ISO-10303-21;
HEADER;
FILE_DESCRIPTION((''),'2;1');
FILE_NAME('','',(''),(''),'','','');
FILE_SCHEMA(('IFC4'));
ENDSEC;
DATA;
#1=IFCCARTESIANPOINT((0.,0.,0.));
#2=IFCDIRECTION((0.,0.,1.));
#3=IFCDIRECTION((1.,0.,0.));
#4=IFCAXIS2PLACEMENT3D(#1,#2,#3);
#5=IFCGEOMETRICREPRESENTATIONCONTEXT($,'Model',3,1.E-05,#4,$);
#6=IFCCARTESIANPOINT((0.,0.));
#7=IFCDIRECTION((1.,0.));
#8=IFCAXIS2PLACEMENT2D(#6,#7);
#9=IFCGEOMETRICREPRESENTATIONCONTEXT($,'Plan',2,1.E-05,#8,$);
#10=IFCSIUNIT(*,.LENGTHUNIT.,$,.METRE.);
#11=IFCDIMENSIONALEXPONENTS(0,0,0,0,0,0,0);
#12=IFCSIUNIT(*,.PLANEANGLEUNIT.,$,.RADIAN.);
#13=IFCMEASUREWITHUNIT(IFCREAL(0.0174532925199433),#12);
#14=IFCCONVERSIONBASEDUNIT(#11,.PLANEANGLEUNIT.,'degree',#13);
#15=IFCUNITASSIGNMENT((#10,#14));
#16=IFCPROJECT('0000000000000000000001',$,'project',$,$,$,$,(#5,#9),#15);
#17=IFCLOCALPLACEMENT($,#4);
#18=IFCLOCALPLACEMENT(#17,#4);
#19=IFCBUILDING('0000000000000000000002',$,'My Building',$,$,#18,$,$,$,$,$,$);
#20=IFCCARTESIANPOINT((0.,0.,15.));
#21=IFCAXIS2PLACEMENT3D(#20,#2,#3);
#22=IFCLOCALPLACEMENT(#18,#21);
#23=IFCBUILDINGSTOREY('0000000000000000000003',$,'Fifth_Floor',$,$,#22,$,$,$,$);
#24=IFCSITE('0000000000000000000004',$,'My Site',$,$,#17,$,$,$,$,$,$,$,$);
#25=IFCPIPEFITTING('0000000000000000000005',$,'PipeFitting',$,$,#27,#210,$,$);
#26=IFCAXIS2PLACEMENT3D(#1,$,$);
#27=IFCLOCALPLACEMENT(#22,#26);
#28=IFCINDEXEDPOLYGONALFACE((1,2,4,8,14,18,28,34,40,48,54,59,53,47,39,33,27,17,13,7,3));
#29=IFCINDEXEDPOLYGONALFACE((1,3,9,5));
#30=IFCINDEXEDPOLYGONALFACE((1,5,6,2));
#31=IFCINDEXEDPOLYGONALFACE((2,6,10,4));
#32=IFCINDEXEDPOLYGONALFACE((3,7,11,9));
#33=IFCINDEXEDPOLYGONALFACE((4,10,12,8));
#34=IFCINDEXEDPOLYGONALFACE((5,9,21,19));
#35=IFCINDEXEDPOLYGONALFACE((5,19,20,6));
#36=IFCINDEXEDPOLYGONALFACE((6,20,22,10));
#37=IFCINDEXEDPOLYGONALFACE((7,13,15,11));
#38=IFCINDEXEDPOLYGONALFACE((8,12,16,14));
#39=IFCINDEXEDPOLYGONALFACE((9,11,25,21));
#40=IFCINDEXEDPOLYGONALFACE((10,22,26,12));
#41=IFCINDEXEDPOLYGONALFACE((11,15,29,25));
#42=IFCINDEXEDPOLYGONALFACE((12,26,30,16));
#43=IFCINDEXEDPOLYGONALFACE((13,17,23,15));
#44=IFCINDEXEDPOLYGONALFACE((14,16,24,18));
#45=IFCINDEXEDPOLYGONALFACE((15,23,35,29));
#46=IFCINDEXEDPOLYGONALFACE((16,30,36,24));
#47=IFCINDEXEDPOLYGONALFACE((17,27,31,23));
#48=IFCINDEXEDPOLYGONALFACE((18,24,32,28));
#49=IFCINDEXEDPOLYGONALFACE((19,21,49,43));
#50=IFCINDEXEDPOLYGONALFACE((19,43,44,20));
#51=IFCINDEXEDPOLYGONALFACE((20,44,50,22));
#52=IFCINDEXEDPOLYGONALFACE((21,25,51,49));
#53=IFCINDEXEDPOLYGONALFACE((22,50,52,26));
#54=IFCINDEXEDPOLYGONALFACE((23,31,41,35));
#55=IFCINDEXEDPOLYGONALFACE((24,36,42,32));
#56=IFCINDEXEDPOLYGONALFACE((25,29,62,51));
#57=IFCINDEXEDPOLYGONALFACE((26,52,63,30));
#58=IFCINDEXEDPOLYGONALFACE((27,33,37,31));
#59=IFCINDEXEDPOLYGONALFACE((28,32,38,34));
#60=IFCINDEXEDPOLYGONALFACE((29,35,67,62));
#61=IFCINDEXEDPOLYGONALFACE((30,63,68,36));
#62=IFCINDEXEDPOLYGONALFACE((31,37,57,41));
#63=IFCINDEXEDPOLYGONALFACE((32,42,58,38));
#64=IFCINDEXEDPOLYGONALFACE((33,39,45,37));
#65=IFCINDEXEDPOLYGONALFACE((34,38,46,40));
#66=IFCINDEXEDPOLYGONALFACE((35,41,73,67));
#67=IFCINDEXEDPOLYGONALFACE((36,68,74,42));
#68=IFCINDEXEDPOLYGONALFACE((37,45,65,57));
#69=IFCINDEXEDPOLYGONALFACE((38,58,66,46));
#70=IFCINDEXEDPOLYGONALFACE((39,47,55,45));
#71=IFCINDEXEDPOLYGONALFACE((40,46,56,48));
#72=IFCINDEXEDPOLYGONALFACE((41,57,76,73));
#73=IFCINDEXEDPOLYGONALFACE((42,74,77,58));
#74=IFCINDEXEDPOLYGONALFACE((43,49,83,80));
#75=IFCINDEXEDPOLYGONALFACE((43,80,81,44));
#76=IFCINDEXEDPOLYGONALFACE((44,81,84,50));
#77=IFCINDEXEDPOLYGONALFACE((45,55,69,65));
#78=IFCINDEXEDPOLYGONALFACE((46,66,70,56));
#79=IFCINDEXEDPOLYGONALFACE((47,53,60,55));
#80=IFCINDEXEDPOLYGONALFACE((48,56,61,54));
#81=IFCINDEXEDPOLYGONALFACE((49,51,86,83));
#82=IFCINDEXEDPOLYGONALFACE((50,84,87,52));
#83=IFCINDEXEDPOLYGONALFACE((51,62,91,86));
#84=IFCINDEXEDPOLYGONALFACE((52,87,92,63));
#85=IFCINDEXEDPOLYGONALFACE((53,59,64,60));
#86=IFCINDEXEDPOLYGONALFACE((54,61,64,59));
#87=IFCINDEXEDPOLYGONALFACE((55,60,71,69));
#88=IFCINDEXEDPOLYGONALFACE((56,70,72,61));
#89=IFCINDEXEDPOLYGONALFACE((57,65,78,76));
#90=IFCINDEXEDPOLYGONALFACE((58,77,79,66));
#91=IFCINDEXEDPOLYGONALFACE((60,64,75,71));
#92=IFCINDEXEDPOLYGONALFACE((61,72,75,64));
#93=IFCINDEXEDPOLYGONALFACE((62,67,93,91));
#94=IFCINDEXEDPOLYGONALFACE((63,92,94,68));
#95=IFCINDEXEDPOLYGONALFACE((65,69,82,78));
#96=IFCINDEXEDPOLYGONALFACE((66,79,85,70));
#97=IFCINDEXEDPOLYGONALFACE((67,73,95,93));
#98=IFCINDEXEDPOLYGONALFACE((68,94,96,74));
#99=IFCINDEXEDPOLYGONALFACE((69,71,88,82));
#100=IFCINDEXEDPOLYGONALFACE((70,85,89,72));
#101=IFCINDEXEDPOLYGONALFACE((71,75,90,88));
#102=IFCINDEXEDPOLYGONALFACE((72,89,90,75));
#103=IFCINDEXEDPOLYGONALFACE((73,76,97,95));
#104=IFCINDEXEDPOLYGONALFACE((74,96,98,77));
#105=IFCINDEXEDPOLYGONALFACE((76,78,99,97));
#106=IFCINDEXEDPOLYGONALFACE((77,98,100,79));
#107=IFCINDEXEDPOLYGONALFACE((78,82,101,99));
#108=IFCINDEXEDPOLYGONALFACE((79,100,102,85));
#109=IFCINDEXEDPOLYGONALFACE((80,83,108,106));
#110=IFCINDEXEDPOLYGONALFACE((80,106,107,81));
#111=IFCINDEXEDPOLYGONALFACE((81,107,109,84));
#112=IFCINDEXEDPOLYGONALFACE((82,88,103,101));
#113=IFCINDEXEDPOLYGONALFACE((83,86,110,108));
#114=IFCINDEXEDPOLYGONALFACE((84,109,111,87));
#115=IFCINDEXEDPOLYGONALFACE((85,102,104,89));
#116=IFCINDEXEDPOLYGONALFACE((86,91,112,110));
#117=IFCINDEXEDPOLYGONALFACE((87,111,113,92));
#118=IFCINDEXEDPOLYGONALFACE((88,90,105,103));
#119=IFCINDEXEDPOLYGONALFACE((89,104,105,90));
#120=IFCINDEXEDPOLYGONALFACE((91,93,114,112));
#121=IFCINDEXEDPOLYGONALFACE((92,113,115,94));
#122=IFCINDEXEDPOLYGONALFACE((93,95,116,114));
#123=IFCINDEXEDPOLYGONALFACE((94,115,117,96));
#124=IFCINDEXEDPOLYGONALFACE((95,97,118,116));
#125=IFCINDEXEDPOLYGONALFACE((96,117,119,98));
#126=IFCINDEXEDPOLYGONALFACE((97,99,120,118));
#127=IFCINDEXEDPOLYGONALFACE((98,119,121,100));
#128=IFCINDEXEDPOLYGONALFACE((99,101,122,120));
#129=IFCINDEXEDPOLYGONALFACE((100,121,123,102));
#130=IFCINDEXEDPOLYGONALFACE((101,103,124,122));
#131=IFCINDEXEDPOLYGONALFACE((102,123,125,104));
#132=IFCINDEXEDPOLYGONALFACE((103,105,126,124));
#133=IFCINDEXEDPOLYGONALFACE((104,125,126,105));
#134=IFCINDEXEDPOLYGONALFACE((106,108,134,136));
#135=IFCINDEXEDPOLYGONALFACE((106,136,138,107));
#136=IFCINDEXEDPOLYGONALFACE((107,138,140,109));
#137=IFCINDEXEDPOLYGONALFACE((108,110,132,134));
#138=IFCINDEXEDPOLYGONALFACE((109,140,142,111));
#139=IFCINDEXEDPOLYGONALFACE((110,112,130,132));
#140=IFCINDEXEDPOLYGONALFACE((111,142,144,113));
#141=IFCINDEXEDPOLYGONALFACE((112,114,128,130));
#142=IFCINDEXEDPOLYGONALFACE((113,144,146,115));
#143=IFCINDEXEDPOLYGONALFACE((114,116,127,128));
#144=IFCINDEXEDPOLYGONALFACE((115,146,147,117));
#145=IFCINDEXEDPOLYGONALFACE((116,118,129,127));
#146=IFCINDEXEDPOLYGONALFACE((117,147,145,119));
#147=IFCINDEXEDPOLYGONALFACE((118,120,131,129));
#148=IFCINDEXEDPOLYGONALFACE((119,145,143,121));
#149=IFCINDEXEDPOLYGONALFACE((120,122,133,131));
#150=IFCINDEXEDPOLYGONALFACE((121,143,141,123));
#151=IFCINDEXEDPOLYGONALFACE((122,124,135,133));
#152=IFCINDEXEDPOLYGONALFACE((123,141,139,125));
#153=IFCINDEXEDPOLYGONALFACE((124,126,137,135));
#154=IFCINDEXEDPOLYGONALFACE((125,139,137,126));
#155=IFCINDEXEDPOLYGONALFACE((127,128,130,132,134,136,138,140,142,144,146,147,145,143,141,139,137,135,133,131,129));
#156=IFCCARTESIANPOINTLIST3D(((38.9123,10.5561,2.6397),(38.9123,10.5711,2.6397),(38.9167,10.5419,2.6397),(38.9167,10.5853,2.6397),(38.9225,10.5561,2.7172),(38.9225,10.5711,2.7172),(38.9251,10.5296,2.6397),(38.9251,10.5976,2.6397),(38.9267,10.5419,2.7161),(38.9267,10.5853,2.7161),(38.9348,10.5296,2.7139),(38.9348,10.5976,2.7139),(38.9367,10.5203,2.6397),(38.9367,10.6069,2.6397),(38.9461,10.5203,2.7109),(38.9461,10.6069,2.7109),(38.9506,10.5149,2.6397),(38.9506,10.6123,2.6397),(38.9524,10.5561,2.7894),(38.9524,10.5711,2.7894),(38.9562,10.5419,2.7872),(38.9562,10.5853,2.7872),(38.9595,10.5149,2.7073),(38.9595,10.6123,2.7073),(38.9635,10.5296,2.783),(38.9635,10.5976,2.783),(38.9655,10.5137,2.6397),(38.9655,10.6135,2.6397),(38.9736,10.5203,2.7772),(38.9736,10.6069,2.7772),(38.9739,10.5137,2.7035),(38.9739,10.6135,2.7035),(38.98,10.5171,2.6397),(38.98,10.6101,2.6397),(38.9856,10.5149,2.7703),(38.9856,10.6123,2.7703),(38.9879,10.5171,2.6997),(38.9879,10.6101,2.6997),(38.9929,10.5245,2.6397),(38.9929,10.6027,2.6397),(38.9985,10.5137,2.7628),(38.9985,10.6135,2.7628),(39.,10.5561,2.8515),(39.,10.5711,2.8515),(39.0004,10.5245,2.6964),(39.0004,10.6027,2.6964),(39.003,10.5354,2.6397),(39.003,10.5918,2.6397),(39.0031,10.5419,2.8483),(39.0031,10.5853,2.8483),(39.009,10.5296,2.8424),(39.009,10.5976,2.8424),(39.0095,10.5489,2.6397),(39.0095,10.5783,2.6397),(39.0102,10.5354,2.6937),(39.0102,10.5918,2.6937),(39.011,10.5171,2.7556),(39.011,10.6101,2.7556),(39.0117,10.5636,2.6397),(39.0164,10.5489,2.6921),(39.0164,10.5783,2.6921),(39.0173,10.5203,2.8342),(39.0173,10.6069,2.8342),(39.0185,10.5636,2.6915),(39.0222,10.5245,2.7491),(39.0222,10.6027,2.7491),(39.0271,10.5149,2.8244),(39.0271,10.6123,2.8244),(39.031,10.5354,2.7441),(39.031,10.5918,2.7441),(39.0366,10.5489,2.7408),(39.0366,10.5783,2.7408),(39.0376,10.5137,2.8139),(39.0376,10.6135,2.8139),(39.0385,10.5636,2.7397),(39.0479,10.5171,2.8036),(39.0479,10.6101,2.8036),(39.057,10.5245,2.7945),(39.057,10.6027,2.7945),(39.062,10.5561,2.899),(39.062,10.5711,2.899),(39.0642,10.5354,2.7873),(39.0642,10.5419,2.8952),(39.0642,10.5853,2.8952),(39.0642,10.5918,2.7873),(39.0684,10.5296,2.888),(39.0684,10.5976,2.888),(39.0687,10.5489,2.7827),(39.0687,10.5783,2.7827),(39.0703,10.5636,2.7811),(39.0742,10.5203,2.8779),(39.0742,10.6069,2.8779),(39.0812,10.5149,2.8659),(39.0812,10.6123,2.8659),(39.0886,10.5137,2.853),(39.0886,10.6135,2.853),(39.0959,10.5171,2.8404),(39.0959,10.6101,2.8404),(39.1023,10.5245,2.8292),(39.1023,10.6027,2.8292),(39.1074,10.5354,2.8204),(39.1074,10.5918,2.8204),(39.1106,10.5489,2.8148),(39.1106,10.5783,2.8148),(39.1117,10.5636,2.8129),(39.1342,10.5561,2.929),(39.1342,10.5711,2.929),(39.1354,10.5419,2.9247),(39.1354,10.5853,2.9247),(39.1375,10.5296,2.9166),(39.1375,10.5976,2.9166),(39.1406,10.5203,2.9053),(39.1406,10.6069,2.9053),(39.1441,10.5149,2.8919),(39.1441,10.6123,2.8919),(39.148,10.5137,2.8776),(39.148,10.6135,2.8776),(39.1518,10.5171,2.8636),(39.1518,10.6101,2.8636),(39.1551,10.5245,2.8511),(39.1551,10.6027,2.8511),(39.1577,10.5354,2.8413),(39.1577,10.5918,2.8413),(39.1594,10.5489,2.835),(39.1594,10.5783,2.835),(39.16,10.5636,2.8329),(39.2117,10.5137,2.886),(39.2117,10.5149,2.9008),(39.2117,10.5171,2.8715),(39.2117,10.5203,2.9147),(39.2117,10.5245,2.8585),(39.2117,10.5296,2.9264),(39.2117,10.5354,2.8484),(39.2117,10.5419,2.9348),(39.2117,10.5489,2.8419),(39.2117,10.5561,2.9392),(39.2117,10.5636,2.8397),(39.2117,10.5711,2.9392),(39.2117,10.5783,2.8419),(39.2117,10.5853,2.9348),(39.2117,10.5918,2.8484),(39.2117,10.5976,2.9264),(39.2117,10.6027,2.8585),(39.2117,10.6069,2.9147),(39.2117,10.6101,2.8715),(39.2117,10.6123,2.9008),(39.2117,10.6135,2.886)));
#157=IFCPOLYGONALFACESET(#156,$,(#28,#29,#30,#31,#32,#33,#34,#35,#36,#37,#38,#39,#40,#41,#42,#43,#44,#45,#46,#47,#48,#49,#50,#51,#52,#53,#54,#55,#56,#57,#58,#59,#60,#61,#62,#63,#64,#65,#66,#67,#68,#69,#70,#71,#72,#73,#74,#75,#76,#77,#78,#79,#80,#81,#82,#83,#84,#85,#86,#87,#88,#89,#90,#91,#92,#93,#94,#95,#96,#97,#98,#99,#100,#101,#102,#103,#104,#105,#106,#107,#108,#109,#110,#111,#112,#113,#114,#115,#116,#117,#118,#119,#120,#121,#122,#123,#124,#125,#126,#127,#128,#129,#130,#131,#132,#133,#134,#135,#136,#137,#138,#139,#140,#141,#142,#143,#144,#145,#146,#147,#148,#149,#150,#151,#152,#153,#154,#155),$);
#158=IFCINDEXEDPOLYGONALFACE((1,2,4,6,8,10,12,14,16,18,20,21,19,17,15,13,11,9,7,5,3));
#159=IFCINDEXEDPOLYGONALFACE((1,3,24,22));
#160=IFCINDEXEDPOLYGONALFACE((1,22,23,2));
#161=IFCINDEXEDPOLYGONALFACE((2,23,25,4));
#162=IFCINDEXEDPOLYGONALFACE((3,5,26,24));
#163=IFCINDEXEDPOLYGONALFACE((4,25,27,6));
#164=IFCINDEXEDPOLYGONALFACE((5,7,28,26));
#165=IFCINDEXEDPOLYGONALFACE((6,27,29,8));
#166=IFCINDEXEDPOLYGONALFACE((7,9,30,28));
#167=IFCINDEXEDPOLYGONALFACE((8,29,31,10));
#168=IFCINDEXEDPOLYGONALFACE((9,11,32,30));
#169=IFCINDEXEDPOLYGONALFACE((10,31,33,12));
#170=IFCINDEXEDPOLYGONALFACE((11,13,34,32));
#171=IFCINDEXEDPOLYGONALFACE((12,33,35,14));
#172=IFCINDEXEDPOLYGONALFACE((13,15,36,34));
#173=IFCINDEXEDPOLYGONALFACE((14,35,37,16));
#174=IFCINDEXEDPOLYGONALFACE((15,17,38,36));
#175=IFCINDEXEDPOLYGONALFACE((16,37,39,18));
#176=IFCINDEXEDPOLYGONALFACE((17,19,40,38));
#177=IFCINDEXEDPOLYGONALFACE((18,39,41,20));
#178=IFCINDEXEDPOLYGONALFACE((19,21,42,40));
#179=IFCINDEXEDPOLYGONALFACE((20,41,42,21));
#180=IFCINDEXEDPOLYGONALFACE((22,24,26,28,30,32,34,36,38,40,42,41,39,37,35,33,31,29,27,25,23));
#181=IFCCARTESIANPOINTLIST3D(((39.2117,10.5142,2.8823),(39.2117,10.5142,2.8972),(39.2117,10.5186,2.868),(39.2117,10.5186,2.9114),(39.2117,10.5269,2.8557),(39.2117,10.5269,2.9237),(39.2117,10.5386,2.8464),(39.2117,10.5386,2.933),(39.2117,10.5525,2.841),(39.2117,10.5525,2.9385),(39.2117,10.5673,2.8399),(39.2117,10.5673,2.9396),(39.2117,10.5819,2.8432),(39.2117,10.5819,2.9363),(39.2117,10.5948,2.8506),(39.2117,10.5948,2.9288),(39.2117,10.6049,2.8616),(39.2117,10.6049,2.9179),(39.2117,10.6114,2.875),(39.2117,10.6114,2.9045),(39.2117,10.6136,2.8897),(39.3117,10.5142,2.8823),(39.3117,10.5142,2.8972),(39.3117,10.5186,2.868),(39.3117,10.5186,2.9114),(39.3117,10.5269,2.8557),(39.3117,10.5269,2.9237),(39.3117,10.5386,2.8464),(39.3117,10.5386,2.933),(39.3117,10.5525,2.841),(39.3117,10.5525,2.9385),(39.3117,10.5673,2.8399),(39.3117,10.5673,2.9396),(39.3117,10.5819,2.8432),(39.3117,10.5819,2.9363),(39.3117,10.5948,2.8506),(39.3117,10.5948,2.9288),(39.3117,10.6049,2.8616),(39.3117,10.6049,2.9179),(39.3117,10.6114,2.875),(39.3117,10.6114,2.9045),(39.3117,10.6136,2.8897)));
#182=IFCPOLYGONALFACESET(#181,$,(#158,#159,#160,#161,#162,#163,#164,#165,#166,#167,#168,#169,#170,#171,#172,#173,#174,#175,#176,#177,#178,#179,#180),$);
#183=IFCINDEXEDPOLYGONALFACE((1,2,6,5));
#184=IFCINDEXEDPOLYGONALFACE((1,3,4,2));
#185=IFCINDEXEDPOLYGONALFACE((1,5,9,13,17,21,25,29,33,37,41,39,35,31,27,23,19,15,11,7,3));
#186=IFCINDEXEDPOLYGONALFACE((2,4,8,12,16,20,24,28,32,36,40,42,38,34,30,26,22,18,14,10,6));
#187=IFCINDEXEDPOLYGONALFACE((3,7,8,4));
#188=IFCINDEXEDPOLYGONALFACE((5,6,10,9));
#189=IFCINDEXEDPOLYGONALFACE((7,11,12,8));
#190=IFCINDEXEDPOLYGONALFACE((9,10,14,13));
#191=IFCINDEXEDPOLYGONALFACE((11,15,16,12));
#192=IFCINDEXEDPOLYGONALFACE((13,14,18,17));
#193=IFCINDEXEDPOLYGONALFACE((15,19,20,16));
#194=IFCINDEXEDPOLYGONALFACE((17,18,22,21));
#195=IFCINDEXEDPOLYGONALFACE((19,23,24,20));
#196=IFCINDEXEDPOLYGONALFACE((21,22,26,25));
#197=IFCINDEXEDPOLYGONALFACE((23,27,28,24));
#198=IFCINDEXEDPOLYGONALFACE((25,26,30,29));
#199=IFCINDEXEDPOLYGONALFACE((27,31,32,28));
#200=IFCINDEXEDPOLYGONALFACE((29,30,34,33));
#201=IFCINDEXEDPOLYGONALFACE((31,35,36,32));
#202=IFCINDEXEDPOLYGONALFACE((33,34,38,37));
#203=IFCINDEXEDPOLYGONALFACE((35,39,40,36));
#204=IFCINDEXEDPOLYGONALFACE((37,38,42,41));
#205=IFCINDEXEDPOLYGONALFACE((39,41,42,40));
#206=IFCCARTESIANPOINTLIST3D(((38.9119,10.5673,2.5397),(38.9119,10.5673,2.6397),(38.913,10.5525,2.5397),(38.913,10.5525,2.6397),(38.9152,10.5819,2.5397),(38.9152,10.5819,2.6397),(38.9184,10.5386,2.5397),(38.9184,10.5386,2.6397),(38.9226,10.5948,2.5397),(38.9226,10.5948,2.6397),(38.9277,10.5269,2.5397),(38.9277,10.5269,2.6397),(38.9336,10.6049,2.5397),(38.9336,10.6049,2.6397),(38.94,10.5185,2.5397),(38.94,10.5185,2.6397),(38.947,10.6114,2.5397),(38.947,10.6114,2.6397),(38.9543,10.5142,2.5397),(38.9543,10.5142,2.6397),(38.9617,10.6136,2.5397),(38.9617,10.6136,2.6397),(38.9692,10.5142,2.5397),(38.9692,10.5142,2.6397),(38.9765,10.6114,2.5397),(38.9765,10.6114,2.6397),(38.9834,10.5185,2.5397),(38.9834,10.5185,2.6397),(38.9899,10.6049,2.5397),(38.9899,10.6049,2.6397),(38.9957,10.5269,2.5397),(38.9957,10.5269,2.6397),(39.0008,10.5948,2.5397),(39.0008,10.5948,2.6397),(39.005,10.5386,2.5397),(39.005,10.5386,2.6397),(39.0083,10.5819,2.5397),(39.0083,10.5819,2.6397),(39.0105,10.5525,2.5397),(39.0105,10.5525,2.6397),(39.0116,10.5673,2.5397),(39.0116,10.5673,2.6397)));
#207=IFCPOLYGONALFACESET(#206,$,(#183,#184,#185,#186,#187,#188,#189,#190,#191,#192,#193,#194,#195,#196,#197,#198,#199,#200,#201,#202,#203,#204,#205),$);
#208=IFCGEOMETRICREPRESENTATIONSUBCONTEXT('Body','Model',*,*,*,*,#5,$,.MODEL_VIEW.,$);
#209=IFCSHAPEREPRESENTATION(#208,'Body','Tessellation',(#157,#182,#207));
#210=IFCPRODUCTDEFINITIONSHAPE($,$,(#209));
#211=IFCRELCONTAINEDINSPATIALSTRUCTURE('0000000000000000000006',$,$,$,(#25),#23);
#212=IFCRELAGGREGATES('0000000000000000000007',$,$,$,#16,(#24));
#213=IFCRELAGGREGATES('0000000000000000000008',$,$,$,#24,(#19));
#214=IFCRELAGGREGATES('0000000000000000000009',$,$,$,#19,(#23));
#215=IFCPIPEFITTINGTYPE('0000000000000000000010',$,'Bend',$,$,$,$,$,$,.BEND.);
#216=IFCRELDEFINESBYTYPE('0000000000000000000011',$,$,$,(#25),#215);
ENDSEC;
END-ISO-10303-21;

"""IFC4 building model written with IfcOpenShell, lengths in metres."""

from ifc_helpers import new_model, entity, si_unit, converted_unit, frame, origin_with_axes, origin_2d_with_axis, place, context, subcontext, project, spatial, circle, extrude, source, transform, mapped, type_object, type_shapes, element, save


model = new_model("IFC4")

# Units and contexts
model_context = context("Model", 3, precision=1e-05, world=origin_with_axes())
plan_context = context("Plan", 2, precision=1e-05, world=origin_2d_with_axis())
body_context_1 = subcontext(model_context, "Body", "Model", "MODEL_VIEW")
ifc_project = project(units=[si_unit("LENGTHUNIT", "METRE"), converted_unit("PLANEANGLEUNIT", "degree", entity("IfcReal", 0.0174532925199433), si_unit("PLANEANGLEUNIT", "RADIAN"), dimensions=[0, 0, 0, 0, 0, 0, 0])], contexts=[model_context, plan_context])

# Site, building, storey
site_placement = place(None, origin_with_axes())
site = spatial("IfcSite", under=ifc_project, at=site_placement, Name="My Site")
building_placement = place(site_placement, origin_with_axes())
building = spatial("IfcBuilding", under=site, at=building_placement, Name="My Building")
storey_placement = place(building_placement, frame((0.0, 0.0, 15.0), z_axis=(0.0, 0.0, 1.0), x_axis=(1.0, 0.0, 0.0)))
storey = spatial("IfcBuildingStorey", under=building, at=storey_placement, Name="Fifth_Floor")

# Pipe fitting
pipe_fitting_type = type_object("IfcPipeFittingType", Name="Bend", PredefinedType="BEND")
shared_shape_1 = source(origin_with_axes(), body_context_1, "Body", "SolidModel", [
    entity("IfcSweptDiskSolid", entity("IfcIndexedPolyCurve", entity("IfcCartesianPointList3D", [[0.0, 0.0, -0.1], [0.0, -0.0732, -0.2768], [0.0, -0.25, -0.35]]), [entity("IfcArcIndex", [1, 2, 3])]), 0.05),
    extrude(circle(Radius=0.05), origin_with_axes(), (0.0, 0.0, -1.0), 0.1),
    extrude(circle(Radius=0.05), frame((0.0, -0.25, -0.35), z_axis=(0.0, -1.0, 0.0), x_axis=(1.0, 0.0, 0.0)), (0.0, 0.0, 1.0), 0.1),
])
type_shapes(pipe_fitting_type, [shared_shape_1])
for number, where, z_axis, x_axis, name in (
    (1, (39.3117, 10.5636, 2.8897), (1.0, 0.000001, 0.0), (-0.000001, 1.0, 0.0), "PipeFitting"),
):
    element("IfcPipeFitting", number, at=place(storey_placement, frame(where, z_axis=z_axis, x_axis=x_axis)), inside=storey, type_object=pipe_fitting_type, Name=name, context=body_context_1, shape_type="MappedRepresentation", body=[
        mapped(shared_shape_1, transform((0.0, 0.0, 0.0), x_axis=(1.0, 0.0, 0.0), y_axis=(0.0, 1.0, 0.0), z_axis=(0.0, 0.0, 1.0), scale=1.0)),
    ])

save(model, "model.ifc")
